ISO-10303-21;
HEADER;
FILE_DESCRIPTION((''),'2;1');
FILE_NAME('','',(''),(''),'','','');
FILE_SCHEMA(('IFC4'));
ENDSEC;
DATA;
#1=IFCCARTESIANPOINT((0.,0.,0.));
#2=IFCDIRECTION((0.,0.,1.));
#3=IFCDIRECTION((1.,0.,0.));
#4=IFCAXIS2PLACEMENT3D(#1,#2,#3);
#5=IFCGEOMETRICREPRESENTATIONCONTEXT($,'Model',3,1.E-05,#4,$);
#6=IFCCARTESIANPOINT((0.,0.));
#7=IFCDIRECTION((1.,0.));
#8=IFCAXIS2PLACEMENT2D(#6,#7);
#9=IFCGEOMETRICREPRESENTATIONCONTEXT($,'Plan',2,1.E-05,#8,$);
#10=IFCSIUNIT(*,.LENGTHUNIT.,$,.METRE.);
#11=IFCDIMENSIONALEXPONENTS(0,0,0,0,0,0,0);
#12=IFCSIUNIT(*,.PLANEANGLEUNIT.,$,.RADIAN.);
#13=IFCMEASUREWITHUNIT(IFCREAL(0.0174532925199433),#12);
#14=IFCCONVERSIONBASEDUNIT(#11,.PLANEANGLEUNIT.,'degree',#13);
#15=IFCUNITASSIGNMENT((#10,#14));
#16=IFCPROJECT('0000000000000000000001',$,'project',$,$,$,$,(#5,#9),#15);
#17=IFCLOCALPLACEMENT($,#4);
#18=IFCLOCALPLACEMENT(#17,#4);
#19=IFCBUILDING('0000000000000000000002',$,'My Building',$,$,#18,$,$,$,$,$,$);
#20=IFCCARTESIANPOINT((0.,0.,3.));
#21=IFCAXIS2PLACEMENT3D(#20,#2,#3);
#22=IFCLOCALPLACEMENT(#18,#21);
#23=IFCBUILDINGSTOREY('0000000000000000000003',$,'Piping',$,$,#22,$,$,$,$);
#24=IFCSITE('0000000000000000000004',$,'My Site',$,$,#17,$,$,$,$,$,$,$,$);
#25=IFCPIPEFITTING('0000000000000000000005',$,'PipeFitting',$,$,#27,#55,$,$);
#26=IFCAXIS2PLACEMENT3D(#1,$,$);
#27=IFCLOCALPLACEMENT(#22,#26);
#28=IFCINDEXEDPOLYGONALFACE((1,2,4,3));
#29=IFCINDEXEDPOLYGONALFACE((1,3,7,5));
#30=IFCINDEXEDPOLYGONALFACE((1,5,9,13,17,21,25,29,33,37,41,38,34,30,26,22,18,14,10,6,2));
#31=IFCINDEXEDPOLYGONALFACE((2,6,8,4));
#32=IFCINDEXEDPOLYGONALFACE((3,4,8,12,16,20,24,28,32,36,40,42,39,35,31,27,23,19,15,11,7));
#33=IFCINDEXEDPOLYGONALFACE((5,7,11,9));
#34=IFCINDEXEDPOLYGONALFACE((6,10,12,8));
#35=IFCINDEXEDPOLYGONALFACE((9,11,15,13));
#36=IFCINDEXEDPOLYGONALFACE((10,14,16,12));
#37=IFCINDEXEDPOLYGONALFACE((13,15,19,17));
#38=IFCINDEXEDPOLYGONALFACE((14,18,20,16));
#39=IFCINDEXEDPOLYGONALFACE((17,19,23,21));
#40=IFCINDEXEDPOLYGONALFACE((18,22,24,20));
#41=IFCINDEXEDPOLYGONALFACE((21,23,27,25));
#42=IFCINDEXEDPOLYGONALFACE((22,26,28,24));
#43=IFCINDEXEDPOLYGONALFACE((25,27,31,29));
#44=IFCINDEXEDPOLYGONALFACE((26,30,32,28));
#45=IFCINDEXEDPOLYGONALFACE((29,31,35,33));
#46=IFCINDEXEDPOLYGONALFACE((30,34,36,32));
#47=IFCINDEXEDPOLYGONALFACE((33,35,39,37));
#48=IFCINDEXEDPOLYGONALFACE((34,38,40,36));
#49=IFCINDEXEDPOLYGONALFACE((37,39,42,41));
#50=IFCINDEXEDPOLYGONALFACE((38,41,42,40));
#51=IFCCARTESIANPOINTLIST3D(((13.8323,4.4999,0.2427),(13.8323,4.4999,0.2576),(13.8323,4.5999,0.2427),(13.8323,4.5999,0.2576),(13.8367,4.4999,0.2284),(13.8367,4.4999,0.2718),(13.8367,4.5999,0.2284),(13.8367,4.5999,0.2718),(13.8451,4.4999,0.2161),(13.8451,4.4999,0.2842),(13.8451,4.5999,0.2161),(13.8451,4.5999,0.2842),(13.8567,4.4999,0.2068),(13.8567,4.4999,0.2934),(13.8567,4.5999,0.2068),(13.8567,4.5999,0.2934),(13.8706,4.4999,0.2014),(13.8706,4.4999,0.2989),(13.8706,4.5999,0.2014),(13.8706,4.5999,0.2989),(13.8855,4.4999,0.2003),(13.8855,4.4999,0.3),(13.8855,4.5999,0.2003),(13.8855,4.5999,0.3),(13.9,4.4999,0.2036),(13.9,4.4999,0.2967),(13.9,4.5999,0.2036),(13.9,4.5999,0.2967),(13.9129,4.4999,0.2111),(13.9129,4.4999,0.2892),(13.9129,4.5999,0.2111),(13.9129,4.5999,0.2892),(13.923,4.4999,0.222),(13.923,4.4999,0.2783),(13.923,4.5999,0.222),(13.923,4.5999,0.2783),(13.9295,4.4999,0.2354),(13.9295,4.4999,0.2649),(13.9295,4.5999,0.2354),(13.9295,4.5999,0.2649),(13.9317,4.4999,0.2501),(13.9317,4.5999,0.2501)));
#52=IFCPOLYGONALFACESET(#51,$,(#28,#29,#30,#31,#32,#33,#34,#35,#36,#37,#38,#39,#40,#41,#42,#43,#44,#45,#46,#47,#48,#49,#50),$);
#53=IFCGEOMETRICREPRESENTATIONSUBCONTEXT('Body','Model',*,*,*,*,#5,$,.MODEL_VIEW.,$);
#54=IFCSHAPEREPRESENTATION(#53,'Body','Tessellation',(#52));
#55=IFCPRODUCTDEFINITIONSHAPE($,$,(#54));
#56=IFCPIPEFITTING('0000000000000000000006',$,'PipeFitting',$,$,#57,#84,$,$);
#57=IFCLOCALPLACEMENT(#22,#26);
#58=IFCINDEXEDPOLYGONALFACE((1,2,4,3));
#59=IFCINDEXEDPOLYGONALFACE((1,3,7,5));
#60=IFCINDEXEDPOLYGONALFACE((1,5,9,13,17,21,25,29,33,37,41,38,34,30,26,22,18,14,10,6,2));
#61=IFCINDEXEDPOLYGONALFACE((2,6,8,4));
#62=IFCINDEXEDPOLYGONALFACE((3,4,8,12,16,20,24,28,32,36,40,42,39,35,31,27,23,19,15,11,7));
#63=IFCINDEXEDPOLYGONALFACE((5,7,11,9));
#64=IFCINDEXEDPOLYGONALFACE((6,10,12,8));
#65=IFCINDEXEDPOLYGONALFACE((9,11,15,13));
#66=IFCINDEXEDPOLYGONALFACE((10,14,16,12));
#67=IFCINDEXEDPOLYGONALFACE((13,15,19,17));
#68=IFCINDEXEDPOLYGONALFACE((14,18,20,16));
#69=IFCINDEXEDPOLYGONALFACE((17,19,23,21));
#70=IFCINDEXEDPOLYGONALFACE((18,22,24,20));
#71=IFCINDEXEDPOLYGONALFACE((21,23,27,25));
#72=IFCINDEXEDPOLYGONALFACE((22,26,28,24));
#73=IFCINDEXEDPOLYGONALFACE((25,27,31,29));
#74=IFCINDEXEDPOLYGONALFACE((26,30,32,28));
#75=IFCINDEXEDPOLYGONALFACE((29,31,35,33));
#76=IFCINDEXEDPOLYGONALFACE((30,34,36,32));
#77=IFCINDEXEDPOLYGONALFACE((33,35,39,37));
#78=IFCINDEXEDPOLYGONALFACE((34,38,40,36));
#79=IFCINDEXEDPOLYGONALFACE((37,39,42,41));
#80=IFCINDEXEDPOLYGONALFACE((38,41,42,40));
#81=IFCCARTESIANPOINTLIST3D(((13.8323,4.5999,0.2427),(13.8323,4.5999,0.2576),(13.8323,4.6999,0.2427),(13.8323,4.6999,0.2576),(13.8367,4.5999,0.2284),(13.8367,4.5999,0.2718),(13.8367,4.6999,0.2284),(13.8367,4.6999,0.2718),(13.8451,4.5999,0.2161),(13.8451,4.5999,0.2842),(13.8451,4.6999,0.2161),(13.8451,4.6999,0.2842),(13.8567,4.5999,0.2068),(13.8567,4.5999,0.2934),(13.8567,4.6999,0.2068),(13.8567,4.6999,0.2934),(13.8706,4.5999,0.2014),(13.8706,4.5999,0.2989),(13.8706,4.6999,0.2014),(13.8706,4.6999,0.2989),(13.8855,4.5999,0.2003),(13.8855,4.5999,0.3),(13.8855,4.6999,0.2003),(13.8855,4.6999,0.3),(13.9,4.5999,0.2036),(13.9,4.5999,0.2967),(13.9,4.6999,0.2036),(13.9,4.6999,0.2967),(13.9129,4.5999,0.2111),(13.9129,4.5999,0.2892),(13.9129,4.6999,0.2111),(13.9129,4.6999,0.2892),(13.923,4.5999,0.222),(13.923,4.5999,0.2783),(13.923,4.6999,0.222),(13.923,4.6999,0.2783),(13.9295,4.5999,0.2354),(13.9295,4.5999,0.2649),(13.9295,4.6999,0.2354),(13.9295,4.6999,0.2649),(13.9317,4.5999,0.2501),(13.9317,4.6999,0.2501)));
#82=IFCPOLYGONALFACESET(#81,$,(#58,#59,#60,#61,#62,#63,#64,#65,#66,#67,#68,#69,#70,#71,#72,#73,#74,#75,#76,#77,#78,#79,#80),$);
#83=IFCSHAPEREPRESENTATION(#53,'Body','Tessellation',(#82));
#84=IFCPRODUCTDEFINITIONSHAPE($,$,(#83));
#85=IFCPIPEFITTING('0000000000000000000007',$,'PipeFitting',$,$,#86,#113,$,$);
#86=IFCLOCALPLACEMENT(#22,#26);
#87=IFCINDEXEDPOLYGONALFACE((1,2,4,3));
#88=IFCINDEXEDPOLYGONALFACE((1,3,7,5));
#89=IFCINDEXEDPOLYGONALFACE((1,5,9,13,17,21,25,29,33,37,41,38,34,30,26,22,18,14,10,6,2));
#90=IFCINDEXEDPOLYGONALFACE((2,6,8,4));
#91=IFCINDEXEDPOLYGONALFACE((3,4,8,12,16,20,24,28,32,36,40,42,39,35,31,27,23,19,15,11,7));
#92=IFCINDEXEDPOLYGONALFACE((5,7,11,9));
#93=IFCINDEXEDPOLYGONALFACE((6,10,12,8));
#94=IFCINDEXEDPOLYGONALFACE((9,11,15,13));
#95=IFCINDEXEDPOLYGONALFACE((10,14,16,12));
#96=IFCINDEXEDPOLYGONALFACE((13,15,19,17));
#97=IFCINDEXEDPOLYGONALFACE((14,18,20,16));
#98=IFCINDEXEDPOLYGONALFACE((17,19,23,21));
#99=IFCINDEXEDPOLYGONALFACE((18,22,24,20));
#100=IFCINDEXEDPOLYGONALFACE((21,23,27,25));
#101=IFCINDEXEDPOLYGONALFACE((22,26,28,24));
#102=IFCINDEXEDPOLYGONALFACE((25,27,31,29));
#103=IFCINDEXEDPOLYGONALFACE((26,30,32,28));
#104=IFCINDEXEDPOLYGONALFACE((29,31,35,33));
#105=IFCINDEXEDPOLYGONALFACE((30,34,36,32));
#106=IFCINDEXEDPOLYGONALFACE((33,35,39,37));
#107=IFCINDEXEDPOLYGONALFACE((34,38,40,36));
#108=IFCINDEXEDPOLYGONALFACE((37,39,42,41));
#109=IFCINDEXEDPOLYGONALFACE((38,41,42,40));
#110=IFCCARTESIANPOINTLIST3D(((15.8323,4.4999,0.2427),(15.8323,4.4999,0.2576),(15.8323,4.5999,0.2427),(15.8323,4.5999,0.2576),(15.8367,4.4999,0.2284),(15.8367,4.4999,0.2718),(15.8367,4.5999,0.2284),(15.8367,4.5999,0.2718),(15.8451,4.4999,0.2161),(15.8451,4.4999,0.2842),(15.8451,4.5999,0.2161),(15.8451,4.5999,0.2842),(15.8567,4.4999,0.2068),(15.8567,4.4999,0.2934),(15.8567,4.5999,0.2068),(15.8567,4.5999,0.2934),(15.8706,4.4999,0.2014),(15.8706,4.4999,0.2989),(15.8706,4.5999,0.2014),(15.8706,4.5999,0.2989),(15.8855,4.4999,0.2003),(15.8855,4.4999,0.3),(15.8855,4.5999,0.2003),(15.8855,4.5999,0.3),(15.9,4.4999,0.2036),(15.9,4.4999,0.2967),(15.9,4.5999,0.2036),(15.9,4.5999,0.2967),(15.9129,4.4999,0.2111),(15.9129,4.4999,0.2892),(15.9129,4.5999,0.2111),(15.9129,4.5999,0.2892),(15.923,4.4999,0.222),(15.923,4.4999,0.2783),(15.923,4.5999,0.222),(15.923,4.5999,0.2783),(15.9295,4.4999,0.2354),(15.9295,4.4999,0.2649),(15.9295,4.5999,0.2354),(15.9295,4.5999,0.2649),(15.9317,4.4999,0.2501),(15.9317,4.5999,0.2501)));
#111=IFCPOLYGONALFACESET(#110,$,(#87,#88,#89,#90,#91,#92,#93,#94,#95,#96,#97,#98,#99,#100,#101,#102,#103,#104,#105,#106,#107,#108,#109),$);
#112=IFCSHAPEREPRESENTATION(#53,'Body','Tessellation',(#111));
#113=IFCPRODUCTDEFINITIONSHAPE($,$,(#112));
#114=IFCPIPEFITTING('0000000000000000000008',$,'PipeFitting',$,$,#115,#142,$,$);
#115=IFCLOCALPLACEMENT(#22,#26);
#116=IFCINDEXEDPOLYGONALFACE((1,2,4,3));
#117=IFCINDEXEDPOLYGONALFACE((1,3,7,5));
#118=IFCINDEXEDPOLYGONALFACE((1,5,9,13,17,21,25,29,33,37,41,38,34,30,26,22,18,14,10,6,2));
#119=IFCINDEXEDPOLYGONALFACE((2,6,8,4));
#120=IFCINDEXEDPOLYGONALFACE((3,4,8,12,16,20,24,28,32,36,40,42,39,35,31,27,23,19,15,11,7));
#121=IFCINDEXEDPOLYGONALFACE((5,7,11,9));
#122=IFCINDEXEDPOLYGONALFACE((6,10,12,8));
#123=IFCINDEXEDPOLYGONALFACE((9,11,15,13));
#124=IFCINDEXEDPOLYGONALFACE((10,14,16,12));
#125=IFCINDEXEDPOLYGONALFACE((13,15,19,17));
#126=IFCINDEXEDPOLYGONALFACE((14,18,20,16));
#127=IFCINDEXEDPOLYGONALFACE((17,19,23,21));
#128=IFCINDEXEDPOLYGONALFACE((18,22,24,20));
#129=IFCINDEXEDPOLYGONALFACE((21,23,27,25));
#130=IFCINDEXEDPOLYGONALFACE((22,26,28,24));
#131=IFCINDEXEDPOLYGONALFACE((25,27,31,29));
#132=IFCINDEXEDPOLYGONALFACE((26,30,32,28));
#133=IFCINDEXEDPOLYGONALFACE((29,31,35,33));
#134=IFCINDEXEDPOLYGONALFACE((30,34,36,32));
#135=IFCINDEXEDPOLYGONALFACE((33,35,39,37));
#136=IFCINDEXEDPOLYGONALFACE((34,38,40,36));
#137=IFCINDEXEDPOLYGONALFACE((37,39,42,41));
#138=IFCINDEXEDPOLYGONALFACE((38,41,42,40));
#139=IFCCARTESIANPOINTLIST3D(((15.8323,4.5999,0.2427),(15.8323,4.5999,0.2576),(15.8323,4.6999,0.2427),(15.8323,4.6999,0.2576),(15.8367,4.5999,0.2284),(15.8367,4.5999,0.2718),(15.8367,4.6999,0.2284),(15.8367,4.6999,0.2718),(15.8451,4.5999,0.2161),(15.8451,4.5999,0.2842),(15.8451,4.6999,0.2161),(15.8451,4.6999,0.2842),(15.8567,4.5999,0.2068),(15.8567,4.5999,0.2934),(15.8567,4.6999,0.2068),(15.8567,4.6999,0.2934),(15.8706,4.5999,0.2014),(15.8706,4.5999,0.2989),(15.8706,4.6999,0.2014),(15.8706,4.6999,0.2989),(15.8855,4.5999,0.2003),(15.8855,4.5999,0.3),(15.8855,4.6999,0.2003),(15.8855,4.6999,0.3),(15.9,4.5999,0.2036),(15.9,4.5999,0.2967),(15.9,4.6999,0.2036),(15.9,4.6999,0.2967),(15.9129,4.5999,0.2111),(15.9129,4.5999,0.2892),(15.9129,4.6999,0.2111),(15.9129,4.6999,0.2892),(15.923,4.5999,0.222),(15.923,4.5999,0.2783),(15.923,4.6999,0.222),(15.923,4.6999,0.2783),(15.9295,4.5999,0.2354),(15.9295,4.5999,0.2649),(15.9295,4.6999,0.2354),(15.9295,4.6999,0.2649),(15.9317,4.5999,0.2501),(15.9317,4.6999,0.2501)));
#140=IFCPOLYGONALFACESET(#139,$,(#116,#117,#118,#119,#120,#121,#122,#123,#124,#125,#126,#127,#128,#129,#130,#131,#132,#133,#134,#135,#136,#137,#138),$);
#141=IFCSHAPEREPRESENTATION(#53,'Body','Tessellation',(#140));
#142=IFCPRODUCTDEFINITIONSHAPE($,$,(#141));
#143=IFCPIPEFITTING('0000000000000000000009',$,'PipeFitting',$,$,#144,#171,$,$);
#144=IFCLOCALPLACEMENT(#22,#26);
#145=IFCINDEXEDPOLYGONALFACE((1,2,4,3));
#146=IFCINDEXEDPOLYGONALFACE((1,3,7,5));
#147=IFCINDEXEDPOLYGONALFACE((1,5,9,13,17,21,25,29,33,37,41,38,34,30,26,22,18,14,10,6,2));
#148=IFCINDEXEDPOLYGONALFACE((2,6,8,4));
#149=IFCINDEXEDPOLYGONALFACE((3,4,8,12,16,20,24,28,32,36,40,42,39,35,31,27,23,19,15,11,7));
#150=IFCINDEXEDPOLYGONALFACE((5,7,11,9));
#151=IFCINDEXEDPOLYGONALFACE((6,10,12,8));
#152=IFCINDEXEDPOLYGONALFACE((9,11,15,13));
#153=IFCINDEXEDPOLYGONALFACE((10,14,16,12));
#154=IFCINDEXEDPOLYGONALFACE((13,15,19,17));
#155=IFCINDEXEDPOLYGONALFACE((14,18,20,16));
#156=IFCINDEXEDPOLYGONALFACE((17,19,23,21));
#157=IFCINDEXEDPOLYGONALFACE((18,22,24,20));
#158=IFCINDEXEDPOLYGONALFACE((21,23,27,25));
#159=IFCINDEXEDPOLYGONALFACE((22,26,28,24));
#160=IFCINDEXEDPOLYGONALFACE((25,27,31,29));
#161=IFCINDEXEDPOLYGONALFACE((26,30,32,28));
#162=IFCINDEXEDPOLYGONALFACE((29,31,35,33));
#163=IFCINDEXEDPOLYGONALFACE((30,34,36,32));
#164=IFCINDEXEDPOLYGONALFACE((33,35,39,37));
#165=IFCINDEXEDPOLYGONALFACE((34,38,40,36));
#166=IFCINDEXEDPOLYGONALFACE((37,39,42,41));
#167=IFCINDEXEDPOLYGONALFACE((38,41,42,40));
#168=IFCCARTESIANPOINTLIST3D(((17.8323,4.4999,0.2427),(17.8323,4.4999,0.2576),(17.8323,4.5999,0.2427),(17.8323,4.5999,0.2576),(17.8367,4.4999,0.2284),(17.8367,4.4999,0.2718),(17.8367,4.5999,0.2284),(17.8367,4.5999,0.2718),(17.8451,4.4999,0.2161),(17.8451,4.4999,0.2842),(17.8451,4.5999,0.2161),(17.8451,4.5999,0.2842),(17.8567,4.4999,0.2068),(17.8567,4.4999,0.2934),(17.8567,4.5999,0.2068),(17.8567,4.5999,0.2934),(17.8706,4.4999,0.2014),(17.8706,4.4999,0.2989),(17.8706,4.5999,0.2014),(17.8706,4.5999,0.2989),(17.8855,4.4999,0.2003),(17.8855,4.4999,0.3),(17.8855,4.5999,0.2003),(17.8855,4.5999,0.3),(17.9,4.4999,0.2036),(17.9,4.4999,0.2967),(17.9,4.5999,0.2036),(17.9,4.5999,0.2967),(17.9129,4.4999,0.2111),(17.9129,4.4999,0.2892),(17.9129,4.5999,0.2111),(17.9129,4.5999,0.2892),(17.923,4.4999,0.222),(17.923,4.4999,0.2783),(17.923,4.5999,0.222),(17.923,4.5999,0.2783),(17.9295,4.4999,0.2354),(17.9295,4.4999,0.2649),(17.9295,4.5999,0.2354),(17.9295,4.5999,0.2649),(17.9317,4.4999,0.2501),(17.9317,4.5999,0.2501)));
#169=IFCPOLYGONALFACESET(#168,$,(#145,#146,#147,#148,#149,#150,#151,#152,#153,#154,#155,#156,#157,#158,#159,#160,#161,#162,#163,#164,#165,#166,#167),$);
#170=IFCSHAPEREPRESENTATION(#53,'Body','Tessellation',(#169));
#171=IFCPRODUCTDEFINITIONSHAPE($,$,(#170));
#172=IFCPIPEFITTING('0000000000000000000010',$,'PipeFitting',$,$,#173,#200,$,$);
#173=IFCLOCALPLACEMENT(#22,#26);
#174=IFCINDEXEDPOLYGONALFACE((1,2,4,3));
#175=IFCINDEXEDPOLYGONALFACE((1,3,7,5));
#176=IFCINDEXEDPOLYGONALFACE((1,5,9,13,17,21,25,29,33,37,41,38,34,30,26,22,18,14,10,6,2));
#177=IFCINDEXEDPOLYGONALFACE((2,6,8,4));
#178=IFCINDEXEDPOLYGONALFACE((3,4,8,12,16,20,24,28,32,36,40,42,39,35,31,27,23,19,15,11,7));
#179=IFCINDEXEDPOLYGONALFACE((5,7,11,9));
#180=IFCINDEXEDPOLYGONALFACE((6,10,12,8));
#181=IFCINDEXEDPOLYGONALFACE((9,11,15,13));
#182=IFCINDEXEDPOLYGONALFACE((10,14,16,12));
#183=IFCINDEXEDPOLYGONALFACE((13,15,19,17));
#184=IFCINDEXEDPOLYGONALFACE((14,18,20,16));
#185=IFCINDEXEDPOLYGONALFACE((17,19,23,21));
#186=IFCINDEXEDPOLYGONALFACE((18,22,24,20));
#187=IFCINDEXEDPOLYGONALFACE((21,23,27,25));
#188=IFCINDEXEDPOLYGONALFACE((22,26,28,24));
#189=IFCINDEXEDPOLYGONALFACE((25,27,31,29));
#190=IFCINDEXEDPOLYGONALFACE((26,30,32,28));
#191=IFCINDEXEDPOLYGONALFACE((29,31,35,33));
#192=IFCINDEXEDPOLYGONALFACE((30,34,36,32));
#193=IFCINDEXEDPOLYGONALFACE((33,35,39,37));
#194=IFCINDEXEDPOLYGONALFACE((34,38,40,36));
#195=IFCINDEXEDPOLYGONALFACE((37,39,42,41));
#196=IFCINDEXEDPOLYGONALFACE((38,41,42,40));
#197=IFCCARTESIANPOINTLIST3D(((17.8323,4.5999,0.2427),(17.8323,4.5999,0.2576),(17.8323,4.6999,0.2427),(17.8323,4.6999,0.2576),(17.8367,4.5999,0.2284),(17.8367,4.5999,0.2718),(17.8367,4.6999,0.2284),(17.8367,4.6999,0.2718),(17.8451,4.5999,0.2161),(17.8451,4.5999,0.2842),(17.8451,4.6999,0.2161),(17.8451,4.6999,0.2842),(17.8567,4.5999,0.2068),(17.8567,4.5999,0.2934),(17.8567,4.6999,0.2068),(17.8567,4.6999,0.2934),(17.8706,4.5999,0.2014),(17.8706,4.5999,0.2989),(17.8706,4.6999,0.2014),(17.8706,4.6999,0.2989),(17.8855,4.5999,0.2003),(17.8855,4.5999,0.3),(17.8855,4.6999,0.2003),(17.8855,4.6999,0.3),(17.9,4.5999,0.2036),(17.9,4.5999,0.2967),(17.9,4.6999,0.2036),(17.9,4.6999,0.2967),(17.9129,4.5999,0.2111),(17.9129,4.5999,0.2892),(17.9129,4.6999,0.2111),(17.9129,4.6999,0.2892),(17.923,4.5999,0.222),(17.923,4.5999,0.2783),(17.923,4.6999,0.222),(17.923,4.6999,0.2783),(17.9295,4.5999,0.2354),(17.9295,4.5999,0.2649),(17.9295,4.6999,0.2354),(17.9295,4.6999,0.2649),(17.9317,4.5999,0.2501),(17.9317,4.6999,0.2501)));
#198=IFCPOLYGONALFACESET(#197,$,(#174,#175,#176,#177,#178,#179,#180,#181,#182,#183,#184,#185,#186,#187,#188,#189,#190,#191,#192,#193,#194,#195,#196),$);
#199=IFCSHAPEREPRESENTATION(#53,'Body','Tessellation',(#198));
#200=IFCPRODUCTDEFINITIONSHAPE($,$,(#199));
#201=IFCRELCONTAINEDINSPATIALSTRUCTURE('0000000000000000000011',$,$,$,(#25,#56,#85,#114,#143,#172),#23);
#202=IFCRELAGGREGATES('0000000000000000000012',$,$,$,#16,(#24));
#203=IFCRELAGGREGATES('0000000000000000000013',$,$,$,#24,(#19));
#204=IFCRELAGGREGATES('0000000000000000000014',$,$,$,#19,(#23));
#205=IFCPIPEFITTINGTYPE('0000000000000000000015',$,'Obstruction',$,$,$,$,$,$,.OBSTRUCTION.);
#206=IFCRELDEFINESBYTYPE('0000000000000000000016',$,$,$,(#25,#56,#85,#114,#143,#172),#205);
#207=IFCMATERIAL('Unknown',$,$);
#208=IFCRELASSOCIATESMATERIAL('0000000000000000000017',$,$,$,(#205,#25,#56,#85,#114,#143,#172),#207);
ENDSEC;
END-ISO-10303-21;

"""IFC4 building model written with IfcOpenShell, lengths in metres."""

from ifc_helpers import new_model, entity, si_unit, converted_unit, frame, origin_with_axes, origin_2d_with_axis, place, context, subcontext, project, spatial, circle, extrude, material, material_profile, profile_set, profile_usage, type_object, element, save


model = new_model("IFC4")

# Units and contexts
model_context = context("Model", 3, precision=1e-05, world=origin_with_axes())
plan_context = context("Plan", 2, precision=1e-05, world=origin_2d_with_axis())
body_context = subcontext(model_context, "Body", "Model", "MODEL_VIEW")
ifc_project = project(units=[si_unit("LENGTHUNIT", "METRE"), converted_unit("PLANEANGLEUNIT", "degree", entity("IfcReal", 0.0174532925199433), si_unit("PLANEANGLEUNIT", "RADIAN"), dimensions=[0, 0, 0, 0, 0, 0, 0])], contexts=[model_context, plan_context])

# Site, building, storey
site_placement = place(None, origin_with_axes())
site = spatial("IfcSite", under=ifc_project, at=site_placement, Name="My Site")
building_placement = place(site_placement, origin_with_axes())
building = spatial("IfcBuilding", under=site, at=building_placement, Name="My Building")
storey_placement = place(building_placement, frame((0.0, 0.0, 3.0), z_axis=(0.0, 0.0, 1.0), x_axis=(1.0, 0.0, 0.0)))
storey = spatial("IfcBuildingStorey", under=building, at=storey_placement, Name="Piping")

# Shared definitions
ifc_material = material(Name="Unknown")

# Pipe fittings
ifc_material_profile_1 = material_profile(ifc_material, circle(Radius=0.05))
ifc_profile_set_1 = profile_set([ifc_material_profile_1])
ifc_profile_usage_1 = profile_usage(ifc_profile_set_1, cardinal=5)
pipe_fitting_type_1 = type_object("IfcPipeFittingType", Name="Obstruction", PredefinedType="OBSTRUCTION", material=ifc_profile_set_1)
pipe_fitting_1_placement = place(storey_placement, frame((13.8817, 4.5999, 0.2501), z_axis=(0.0, -1.0, 0.000008), x_axis=(1.0, 0.0, 0.0)))
element("IfcPipeFitting", 1, at=pipe_fitting_1_placement, inside=storey, type_object=pipe_fitting_type_1, material=ifc_profile_usage_1, Name="PipeFitting", context=body_context, shape_type="SweptSolid", body=[
    extrude(circle(Radius=0.05), origin_with_axes(), (0.0, 0.0, 1.0), 0.1),
])
ifc_profile_usage_2 = profile_usage(ifc_profile_set_1, cardinal=5)
pipe_fitting_2_placement = place(storey_placement, frame((13.8817, 4.5999, 0.2501), z_axis=(0.0, 1.0, -0.000008), x_axis=(1.0, 0.0, 0.0)))
element("IfcPipeFitting", 2, at=pipe_fitting_2_placement, inside=storey, type_object=pipe_fitting_type_1, material=ifc_profile_usage_2, Name="PipeFitting", context=body_context, shape_type="SweptSolid", body=[
    extrude(circle(Radius=0.05), origin_with_axes(), (0.0, 0.0, 1.0), 0.1),
])
ifc_profile_usage_3 = profile_usage(ifc_profile_set_1, cardinal=5)
pipe_fitting_3_placement = place(storey_placement, frame((15.8817, 4.5999, 0.2501), z_axis=(0.0, -1.0, 0.000008), x_axis=(1.0, 0.0, 0.0)))
element("IfcPipeFitting", 3, at=pipe_fitting_3_placement, inside=storey, type_object=pipe_fitting_type_1, material=ifc_profile_usage_3, Name="PipeFitting", context=body_context, shape_type="SweptSolid", body=[
    extrude(circle(Radius=0.05), origin_with_axes(), (0.0, 0.0, 1.0), 0.1),
])
ifc_profile_usage_4 = profile_usage(ifc_profile_set_1, cardinal=5)
pipe_fitting_4_placement = place(storey_placement, frame((15.8817, 4.5999, 0.2501), z_axis=(0.0, 1.0, -0.000008), x_axis=(1.0, 0.0, 0.0)))
element("IfcPipeFitting", 4, at=pipe_fitting_4_placement, inside=storey, type_object=pipe_fitting_type_1, material=ifc_profile_usage_4, Name="PipeFitting", context=body_context, shape_type="SweptSolid", body=[
    extrude(circle(Radius=0.05), origin_with_axes(), (0.0, 0.0, 1.0), 0.1),
])
ifc_profile_usage_5 = profile_usage(ifc_profile_set_1, cardinal=5)
pipe_fitting_5_placement = place(storey_placement, frame((17.8817, 4.5999, 0.2501), z_axis=(0.0, -1.0, 0.000008), x_axis=(1.0, 0.0, 0.0)))
element("IfcPipeFitting", 5, at=pipe_fitting_5_placement, inside=storey, type_object=pipe_fitting_type_1, material=ifc_profile_usage_5, Name="PipeFitting", context=body_context, shape_type="SweptSolid", body=[
    extrude(circle(Radius=0.05), origin_with_axes(), (0.0, 0.0, 1.0), 0.1),
])
ifc_profile_usage_6 = profile_usage(ifc_profile_set_1, cardinal=5)
pipe_fitting_6_placement = place(storey_placement, frame((17.8817, 4.5999, 0.2501), z_axis=(0.0, 1.0, -0.000008), x_axis=(1.0, 0.0, 0.0)))
element("IfcPipeFitting", 6, at=pipe_fitting_6_placement, inside=storey, type_object=pipe_fitting_type_1, material=ifc_profile_usage_6, Name="PipeFitting", context=body_context, shape_type="SweptSolid", body=[
    extrude(circle(Radius=0.05), origin_with_axes(), (0.0, 0.0, 1.0), 0.1),
])

save(model, "model.ifc")
